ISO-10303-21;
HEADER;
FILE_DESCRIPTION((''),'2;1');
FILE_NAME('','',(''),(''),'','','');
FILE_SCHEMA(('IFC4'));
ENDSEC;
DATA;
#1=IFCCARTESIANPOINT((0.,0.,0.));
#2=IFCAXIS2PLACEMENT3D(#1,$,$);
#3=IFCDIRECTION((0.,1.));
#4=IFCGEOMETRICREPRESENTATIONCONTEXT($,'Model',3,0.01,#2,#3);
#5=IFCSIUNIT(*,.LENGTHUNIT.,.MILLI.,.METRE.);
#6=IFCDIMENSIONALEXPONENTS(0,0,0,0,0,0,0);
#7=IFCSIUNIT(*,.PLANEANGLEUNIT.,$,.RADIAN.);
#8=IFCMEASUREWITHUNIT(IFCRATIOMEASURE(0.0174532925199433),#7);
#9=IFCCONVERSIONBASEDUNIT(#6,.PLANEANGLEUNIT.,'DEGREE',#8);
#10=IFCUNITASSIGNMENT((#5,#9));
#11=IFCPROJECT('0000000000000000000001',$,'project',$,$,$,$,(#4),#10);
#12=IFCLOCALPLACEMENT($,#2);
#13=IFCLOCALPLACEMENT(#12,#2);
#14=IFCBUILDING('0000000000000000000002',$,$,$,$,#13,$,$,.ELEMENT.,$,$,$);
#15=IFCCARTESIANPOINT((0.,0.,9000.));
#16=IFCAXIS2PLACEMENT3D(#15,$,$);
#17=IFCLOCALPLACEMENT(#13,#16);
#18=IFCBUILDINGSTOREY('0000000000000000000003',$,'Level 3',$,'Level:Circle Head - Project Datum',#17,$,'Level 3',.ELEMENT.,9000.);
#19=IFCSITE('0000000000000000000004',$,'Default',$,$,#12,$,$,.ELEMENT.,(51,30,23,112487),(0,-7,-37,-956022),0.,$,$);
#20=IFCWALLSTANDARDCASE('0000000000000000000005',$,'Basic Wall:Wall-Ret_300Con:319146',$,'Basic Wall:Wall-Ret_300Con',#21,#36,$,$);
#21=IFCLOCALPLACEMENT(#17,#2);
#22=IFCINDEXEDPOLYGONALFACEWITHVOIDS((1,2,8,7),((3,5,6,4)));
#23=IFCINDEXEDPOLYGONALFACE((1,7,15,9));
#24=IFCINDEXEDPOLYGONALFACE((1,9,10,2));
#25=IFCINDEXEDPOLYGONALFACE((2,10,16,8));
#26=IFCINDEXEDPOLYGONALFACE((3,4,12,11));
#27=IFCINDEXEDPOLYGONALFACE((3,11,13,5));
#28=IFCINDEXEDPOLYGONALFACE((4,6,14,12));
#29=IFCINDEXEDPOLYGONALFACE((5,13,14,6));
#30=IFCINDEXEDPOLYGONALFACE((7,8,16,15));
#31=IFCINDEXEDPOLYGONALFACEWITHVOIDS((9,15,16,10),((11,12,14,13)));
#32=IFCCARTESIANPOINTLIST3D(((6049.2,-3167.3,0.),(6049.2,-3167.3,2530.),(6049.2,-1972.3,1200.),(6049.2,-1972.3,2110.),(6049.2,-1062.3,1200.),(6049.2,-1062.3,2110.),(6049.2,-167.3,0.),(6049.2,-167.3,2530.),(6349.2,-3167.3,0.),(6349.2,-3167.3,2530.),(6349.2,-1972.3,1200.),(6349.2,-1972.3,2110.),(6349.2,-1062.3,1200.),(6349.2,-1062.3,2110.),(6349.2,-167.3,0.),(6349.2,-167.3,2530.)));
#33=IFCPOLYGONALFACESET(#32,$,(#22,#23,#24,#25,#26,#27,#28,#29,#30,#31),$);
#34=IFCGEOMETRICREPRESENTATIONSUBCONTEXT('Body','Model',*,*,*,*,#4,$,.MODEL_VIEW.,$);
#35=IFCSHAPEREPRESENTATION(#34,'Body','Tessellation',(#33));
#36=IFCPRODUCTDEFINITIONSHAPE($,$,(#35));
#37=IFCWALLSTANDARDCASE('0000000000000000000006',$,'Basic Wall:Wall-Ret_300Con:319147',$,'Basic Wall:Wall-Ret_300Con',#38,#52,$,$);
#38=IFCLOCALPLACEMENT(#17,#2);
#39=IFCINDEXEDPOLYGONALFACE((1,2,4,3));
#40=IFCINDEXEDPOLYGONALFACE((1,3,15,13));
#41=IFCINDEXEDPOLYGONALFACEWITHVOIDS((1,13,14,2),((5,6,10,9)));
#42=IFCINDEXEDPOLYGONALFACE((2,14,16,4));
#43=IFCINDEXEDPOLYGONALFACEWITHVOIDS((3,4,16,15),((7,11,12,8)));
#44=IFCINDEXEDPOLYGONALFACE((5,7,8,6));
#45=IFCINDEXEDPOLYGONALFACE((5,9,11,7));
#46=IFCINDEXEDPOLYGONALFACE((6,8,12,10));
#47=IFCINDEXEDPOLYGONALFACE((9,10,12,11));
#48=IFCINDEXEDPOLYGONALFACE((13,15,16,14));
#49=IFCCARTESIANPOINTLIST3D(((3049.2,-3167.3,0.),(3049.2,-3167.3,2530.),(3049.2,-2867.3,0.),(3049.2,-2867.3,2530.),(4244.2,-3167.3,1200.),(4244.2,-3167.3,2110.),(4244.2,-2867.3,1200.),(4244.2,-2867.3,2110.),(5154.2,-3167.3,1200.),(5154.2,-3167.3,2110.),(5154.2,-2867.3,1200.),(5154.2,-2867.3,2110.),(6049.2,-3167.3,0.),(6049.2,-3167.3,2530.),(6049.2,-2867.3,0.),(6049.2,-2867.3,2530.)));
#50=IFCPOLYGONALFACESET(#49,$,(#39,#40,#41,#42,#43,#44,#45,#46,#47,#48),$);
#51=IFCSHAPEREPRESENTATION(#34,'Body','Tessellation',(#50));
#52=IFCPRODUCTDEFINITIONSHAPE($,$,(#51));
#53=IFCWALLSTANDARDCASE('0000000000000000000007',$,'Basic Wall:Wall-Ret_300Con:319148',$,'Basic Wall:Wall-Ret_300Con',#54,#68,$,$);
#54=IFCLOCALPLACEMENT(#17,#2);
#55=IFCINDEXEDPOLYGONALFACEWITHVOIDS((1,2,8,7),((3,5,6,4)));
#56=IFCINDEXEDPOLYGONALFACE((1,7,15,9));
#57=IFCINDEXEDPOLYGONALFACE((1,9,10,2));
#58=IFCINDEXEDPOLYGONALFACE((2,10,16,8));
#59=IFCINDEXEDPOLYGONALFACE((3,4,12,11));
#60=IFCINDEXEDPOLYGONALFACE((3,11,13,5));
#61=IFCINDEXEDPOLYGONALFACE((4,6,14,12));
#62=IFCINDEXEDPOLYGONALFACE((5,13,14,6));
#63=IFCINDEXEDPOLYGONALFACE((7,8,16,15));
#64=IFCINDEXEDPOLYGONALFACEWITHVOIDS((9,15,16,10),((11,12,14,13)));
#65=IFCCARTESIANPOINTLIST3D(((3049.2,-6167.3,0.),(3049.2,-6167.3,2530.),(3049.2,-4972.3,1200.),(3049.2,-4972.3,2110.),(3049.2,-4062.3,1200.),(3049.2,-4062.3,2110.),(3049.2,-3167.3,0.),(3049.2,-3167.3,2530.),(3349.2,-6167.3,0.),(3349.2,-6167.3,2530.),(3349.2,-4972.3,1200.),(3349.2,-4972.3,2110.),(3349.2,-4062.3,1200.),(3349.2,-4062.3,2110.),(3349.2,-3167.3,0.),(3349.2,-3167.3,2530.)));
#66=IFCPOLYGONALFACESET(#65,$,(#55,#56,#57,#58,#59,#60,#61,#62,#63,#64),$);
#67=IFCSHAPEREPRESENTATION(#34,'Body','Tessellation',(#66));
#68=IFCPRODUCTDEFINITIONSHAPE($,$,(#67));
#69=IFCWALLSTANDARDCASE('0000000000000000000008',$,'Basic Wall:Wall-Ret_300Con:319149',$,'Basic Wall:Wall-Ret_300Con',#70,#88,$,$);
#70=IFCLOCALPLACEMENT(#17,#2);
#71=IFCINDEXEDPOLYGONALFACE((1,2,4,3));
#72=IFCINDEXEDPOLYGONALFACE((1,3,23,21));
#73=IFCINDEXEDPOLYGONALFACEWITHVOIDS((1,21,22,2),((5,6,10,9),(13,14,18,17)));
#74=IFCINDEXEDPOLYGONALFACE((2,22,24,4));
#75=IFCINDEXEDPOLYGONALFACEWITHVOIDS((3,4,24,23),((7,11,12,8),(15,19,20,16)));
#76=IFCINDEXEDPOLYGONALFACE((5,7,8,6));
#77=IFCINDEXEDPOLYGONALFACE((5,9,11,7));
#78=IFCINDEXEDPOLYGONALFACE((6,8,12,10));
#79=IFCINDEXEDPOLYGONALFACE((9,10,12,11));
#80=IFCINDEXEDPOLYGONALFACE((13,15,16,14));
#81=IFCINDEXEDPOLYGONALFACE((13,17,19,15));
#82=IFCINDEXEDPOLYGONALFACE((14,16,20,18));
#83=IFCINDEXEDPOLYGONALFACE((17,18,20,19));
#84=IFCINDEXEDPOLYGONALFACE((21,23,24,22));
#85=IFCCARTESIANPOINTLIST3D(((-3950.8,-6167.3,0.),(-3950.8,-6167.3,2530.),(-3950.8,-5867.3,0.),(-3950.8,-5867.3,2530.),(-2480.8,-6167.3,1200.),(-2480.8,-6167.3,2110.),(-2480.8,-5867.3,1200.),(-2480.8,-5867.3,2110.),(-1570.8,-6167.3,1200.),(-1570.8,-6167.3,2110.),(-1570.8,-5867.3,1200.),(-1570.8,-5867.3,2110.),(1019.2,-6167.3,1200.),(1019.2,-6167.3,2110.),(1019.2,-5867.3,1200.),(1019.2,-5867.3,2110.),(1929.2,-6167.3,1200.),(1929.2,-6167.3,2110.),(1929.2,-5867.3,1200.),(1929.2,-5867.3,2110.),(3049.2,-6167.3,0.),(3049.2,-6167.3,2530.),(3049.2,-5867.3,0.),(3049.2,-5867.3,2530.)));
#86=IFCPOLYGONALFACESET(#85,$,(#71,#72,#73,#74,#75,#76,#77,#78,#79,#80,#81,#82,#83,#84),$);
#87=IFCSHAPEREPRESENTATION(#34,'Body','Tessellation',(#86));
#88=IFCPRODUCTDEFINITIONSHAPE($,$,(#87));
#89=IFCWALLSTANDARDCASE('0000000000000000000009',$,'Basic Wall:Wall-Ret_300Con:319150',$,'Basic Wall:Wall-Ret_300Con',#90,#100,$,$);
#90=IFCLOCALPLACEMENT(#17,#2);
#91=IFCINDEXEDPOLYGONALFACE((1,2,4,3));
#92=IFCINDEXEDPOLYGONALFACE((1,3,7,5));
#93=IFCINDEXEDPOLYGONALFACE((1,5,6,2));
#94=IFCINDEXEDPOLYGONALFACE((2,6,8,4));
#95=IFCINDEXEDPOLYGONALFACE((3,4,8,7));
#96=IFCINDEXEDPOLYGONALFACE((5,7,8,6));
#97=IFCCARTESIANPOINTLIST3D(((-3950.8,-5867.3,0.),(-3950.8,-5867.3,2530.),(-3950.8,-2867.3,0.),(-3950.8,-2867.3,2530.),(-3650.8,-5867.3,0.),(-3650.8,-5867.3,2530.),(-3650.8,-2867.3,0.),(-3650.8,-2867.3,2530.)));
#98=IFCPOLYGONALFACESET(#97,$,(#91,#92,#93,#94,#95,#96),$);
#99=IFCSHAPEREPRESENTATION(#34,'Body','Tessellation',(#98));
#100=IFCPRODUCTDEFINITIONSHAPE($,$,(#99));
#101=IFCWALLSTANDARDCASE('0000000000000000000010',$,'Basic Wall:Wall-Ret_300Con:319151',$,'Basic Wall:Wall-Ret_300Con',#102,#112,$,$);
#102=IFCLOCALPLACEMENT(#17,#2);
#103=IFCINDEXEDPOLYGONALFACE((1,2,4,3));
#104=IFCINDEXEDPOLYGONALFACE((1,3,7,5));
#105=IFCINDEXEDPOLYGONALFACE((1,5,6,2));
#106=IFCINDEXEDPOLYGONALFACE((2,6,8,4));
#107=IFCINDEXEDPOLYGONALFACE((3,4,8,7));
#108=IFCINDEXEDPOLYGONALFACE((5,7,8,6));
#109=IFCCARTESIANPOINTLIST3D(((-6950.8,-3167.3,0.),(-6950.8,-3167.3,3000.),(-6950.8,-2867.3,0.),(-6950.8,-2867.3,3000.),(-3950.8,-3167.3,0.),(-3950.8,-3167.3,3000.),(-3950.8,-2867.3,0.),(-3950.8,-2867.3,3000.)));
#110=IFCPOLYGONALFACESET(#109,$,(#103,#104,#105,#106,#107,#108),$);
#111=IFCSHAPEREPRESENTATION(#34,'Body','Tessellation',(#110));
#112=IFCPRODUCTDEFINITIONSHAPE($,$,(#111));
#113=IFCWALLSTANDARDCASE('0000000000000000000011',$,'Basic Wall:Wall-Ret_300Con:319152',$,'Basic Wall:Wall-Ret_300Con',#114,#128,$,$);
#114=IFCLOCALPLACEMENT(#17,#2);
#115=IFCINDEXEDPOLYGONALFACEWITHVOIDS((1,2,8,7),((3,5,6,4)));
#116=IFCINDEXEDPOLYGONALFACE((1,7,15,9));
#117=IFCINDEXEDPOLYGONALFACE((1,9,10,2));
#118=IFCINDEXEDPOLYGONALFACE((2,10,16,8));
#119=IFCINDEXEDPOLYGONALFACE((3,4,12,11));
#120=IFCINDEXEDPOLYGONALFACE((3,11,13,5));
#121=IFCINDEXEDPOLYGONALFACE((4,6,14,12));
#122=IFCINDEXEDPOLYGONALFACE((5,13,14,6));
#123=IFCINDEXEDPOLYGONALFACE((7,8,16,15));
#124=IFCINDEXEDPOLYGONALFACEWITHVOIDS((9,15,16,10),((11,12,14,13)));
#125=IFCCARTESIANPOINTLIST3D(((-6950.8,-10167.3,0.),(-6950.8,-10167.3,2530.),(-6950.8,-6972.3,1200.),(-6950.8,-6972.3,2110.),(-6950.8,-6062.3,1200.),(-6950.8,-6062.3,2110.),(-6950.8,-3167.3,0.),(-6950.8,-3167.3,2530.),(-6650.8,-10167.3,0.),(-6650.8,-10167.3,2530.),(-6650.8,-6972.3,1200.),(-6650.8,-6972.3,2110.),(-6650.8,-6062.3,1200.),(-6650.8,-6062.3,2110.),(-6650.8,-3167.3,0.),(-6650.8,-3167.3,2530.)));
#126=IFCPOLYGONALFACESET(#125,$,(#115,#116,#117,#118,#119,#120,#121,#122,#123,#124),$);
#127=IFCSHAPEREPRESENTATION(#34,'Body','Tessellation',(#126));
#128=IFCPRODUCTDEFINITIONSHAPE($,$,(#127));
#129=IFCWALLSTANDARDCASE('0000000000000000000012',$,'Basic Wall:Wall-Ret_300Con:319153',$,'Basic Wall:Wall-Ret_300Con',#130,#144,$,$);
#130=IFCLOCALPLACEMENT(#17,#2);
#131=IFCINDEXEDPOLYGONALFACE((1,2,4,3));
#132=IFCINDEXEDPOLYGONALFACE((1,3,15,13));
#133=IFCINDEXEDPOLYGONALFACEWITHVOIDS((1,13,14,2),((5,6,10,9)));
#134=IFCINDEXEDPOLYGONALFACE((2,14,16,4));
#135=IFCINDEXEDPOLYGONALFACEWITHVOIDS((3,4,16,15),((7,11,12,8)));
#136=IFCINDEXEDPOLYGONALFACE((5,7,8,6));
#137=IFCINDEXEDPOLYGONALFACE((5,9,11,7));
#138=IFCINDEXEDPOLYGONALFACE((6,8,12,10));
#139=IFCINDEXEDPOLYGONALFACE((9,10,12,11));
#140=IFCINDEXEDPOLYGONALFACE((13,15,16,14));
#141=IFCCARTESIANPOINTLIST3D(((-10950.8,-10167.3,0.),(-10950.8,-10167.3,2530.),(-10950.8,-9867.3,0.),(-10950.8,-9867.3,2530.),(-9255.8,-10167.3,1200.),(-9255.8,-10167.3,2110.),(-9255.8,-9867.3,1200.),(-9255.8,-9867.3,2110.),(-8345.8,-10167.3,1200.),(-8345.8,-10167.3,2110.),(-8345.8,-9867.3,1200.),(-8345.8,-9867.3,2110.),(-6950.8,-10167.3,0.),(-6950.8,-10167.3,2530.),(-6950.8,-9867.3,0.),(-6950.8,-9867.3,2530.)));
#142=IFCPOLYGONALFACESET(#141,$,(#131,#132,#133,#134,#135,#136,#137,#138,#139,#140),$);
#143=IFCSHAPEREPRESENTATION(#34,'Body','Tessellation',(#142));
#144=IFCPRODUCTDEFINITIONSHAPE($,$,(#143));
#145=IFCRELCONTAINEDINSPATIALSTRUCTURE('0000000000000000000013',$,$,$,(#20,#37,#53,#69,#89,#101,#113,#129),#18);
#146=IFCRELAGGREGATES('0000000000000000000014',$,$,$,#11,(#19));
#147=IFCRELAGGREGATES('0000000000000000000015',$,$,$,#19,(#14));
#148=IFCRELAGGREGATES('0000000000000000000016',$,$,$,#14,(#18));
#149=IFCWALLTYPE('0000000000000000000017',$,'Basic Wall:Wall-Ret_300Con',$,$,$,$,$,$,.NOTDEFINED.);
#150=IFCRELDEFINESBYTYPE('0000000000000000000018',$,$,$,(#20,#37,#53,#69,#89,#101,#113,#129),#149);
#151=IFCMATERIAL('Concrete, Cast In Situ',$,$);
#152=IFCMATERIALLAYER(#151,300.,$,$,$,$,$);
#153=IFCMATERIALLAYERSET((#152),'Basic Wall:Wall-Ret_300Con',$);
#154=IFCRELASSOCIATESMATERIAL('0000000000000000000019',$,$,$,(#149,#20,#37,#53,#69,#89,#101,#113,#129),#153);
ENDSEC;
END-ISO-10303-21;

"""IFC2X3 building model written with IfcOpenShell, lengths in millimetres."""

from ifc_helpers import new_model, entity, si_unit, converted_unit, direction, frame, frame_2d, origin, place, context, subcontext, project, spatial, polyline, rectangle, extrude, clip, bounded_halfspace, material, layer, layer_set, layer_usage, type_object, element, save


model = new_model("IFC2X3")

# Units and contexts
model_context = context("Model", 3, precision=0.01, world=origin(), true_north=direction((0.0, 1.0)))
body_context = subcontext(model_context, "Body", "Model", "MODEL_VIEW")
ifc_project = project(units=[si_unit("LENGTHUNIT", "METRE", prefix="MILLI"), converted_unit("PLANEANGLEUNIT", "DEGREE", entity("IfcRatioMeasure", 0.0174532925199433), si_unit("PLANEANGLEUNIT", "RADIAN"), dimensions=[0, 0, 0, 0, 0, 0, 0])], contexts=[model_context])

# Site, building, storey
site_placement = place(None, origin())
site = spatial("IfcSite", under=ifc_project, at=site_placement, Name="Default", CompositionType="ELEMENT", RefLatitude=(51, 30, 23, 112487), RefLongitude=(0, -7, -37, -956022), RefElevation=0.0)
building_placement = place(site_placement, origin())
building = spatial("IfcBuilding", under=site, at=building_placement, CompositionType="ELEMENT")
storey_placement = place(building_placement, frame((0.0, 0.0, 9000.0)))
storey = spatial("IfcBuildingStorey", under=building, at=storey_placement, Name="Level 3", ObjectType="Level:Circle Head - Project Datum", LongName="Level 3", CompositionType="ELEMENT", Elevation=9000.0)

# Walls, openings
ifc_material_1 = material(Name="Concrete, Cast In Situ")
ifc_layer_1 = layer(ifc_material_1, 300.0)
ifc_layer_set_1 = layer_set([ifc_layer_1], Name="Basic Wall:Wall-Ret_300Con")
wall_type = type_object("IfcWallType", Name="Basic Wall:Wall-Ret_300Con", PredefinedType="NOTDEFINED", material=ifc_layer_set_1)
ifc_layer_usage_1 = layer_usage(ifc_layer_set_1, "AXIS2", "NEGATIVE", 150.0)
wall_1_placement = place(storey_placement, frame((6199.2, -167.3, 0.0), z_axis=(0.0, 0.0, 1.0), x_axis=(0.0, -1.0, 0.0)))
wall_1 = element("IfcWallStandardCase", 1, at=wall_1_placement, inside=storey, type_object=wall_type, material=ifc_layer_usage_1, Name="Basic Wall:Wall-Ret_300Con:319146", ObjectType="Basic Wall:Wall-Ret_300Con", context=body_context, shape_type="Clipping", body=[
    clip(extrude(rectangle(XDim=3000.0, YDim=300.0, at=frame_2d((1500.0, 0.0), x_axis=(-1.0, 0.0))), origin(), (0.0, 0.0, 1.0), 2530.0), bounded_halfspace(frame((0.0, -150.0, 2530.0), z_axis=(0.0, 0.0, -1.0), x_axis=(0.0, 1.0, 0.0)), True, frame((0.0, -150.0, 2530.0)), polyline([(0.0, 0.0), (2700.0, 0.0), (2998.0, 0.0), (2998.0, 298.7), (0.0, 298.7), (0.0, 0.0)]))),
])
opening_1_placement = place(wall_1_placement, frame((1805.0, 150.0, 1200.0)))
element("IfcOpeningElement", 2, at=opening_1_placement, cuts=wall_1, ObjectType="Opening", context=body_context, shape_type="SweptSolid", body=[
    extrude(rectangle(XDim=910.0, YDim=910.0, at=frame_2d((455.0, 455.0), x_axis=(-1.0, 0.0))), frame((0.0, 0.0, 0.0), z_axis=(0.0, -1.0, 0.0), x_axis=(0.0, 0.0, 1.0)), (0.0, 0.0, 1.0), 300.0),
])
ifc_layer_usage_2 = layer_usage(ifc_layer_set_1, "AXIS2", "NEGATIVE", 150.0)
wall_2_placement = place(storey_placement, frame((6049.2, -3017.3, 0.0), z_axis=(0.0, 0.0, 1.0), x_axis=(-1.0, 0.0, 0.0)))
wall_2 = element("IfcWallStandardCase", 3, at=wall_2_placement, inside=storey, type_object=wall_type, material=ifc_layer_usage_2, Name="Basic Wall:Wall-Ret_300Con:319147", ObjectType="Basic Wall:Wall-Ret_300Con", context=body_context, shape_type="Clipping", body=[
    clip(extrude(rectangle(XDim=3000.0, YDim=300.0, at=frame_2d((1500.0, 0.0), x_axis=(-1.0, 0.0))), origin(), (0.0, 0.0, 1.0), 2530.0), bounded_halfspace(frame((0.0, -150.0, 2530.0), z_axis=(0.0, 0.0, -1.0), x_axis=(-1.0, 0.0, 0.0)), True, frame((0.0, -150.0, 2530.0)), polyline([(0.0, 0.0), (3000.0, 0.0), (3000.0, 298.0), (2701.3, 298.0), (0.0, 298.0), (0.0, 0.0)]))),
])
opening_2_placement = place(wall_2_placement, frame((1805.0, 150.0, 1200.0)))
element("IfcOpeningElement", 4, at=opening_2_placement, cuts=wall_2, ObjectType="Opening", context=body_context, shape_type="SweptSolid", body=[
    extrude(rectangle(XDim=910.0, YDim=910.0, at=frame_2d((455.0, 455.0), x_axis=(-1.0, 0.0))), frame((0.0, 0.0, 0.0), z_axis=(0.0, -1.0, 0.0), x_axis=(0.0, 0.0, 1.0)), (0.0, 0.0, 1.0), 300.0),
])
ifc_layer_usage_3 = layer_usage(ifc_layer_set_1, "AXIS2", "NEGATIVE", 150.0)
wall_3_placement = place(storey_placement, frame((3199.2, -3167.3, 0.0), z_axis=(0.0, 0.0, 1.0), x_axis=(0.0, -1.0, 0.0)))
wall_3 = element("IfcWallStandardCase", 5, at=wall_3_placement, inside=storey, type_object=wall_type, material=ifc_layer_usage_3, Name="Basic Wall:Wall-Ret_300Con:319148", ObjectType="Basic Wall:Wall-Ret_300Con", context=body_context, shape_type="Clipping", body=[
    clip(extrude(rectangle(XDim=3000.0, YDim=300.0, at=frame_2d((1500.0, 0.0), x_axis=(-1.0, 0.0))), origin(), (0.0, 0.0, 1.0), 2530.0), bounded_halfspace(frame((0.0, -150.0, 2530.0), z_axis=(0.0, 0.0, -1.0), x_axis=(0.0, 1.0, 0.0)), True, frame((0.0, -150.0, 2530.0)), polyline([(0.0, 0.0), (2700.0, 0.0), (2998.0, 0.0), (2998.0, 298.7), (0.0, 298.7), (0.0, 0.0)]))),
])
opening_3_placement = place(wall_3_placement, frame((895.0, -150.0, 1200.0)))
element("IfcOpeningElement", 6, at=opening_3_placement, cuts=wall_3, ObjectType="Opening", context=body_context, shape_type="SweptSolid", body=[
    extrude(rectangle(XDim=910.0, YDim=910.0, at=frame_2d((455.0, 455.0), x_axis=(-1.0, 0.0))), frame((0.0, 0.0, 0.0), z_axis=(0.0, 1.0, 0.0), x_axis=(0.0, 0.0, 1.0)), (0.0, 0.0, 1.0), 300.0),
])

# Wall, openings
ifc_layer_usage_4 = layer_usage(ifc_layer_set_1, "AXIS2", "NEGATIVE", 150.0)
wall_4_placement = place(storey_placement, frame((3049.2, -6017.3, 0.0), z_axis=(0.0, 0.0, 1.0), x_axis=(-1.0, 0.0, 0.0)))
wall_4 = element("IfcWallStandardCase", 7, at=wall_4_placement, inside=storey, type_object=wall_type, material=ifc_layer_usage_4, Name="Basic Wall:Wall-Ret_300Con:319149", ObjectType="Basic Wall:Wall-Ret_300Con", context=body_context, shape_type="Clipping", body=[
    clip(extrude(rectangle(XDim=7000.0, YDim=300.0, at=frame_2d((3500.0, 0.0), x_axis=(-1.0, 0.0))), origin(), (0.0, 0.0, 1.0), 2530.0), bounded_halfspace(frame((0.0, -150.0, 2530.0), z_axis=(0.0, 0.0, -1.0), x_axis=(-1.0, 0.0, 0.0)), True, frame((0.0, -150.0, 2530.0)), polyline([(0.0, 0.0), (6700.0, 0.0), (7000.0, 0.0), (7000.0, 298.0), (0.0, 298.0), (0.0, 0.0)]))),
])
opening_4_placement = place(wall_4_placement, frame((2030.0, 150.0, 1200.0)))
element("IfcOpeningElement", 8, at=opening_4_placement, cuts=wall_4, ObjectType="Opening", context=body_context, shape_type="SweptSolid", body=[
    extrude(rectangle(XDim=910.0, YDim=910.0, at=frame_2d((455.0, 455.0), x_axis=(-1.0, 0.0))), frame((0.0, 0.0, 0.0), z_axis=(0.0, -1.0, 0.0), x_axis=(0.0, 0.0, 1.0)), (0.0, 0.0, 1.0), 300.0),
])
opening_5_placement = place(wall_4_placement, frame((4620.0, -150.0, 1200.0)))
element("IfcOpeningElement", 9, at=opening_5_placement, cuts=wall_4, ObjectType="Opening", context=body_context, shape_type="SweptSolid", body=[
    extrude(rectangle(XDim=910.0, YDim=910.0, at=frame_2d((455.0, 455.0), x_axis=(-1.0, 0.0))), frame((0.0, 0.0, 0.0), z_axis=(0.0, 1.0, 0.0), x_axis=(0.0, 0.0, 1.0)), (0.0, 0.0, 1.0), 300.0),
])

# Walls
ifc_layer_usage_5 = layer_usage(ifc_layer_set_1, "AXIS2", "NEGATIVE", 150.0)
wall_5_placement = place(storey_placement, frame((-3800.8, -5867.3, 0.0), z_axis=(0.0, 0.0, 1.0), x_axis=(0.0, 1.0, 0.0)))
element("IfcWallStandardCase", 10, at=wall_5_placement, inside=storey, type_object=wall_type, material=ifc_layer_usage_5, Name="Basic Wall:Wall-Ret_300Con:319150", ObjectType="Basic Wall:Wall-Ret_300Con", context=body_context, shape_type="Clipping", body=[
    clip(extrude(rectangle(XDim=3000.0, YDim=300.0, at=frame_2d((1500.0, 0.0), x_axis=(-1.0, 0.0))), origin(), (0.0, 0.0, 1.0), 2530.0), bounded_halfspace(frame((0.0, -150.0, 2530.0), z_axis=(0.0, 0.0, -1.0), x_axis=(0.0, -1.0, 0.0)), True, frame((0.0, -150.0, 2530.0)), polyline([(0.0, 0.0), (3000.0, 0.0), (3000.0, 300.0), (0.0, 300.0), (0.0, 0.0)]))),
])
ifc_layer_usage_6 = layer_usage(ifc_layer_set_1, "AXIS2", "NEGATIVE", 150.0)
wall_6_placement = place(storey_placement, frame((-3950.8, -3017.3, 0.0), z_axis=(0.0, 0.0, 1.0), x_axis=(-1.0, 0.0, 0.0)))
element("IfcWallStandardCase", 11, at=wall_6_placement, inside=storey, type_object=wall_type, material=ifc_layer_usage_6, Name="Basic Wall:Wall-Ret_300Con:319151", ObjectType="Basic Wall:Wall-Ret_300Con", context=body_context, shape_type="SweptSolid", body=[
    extrude(rectangle(XDim=3000.0, YDim=300.0, at=frame_2d((1500.0, 0.0), x_axis=(-1.0, 0.0))), origin(), (0.0, 0.0, 1.0), 3000.0),
])

# Walls, openings
ifc_layer_usage_7 = layer_usage(ifc_layer_set_1, "AXIS2", "NEGATIVE", 150.0)
wall_7_placement = place(storey_placement, frame((-6800.8, -3167.3, 0.0), z_axis=(0.0, 0.0, 1.0), x_axis=(0.0, -1.0, 0.0)))
wall_7 = element("IfcWallStandardCase", 12, at=wall_7_placement, inside=storey, type_object=wall_type, material=ifc_layer_usage_7, Name="Basic Wall:Wall-Ret_300Con:319152", ObjectType="Basic Wall:Wall-Ret_300Con", context=body_context, shape_type="Clipping", body=[
    clip(extrude(rectangle(XDim=7000.0, YDim=300.0, at=frame_2d((3500.0, 0.0), x_axis=(-1.0, 0.0))), origin(), (0.0, 0.0, 1.0), 2530.0), bounded_halfspace(frame((0.0, -150.0, 2530.0), z_axis=(0.0, 0.0, -1.0), x_axis=(0.0, 1.0, 0.0)), True, frame((0.0, -150.0, 2530.0)), polyline([(0.0, 0.0), (6700.0, 0.0), (6998.0, 0.0), (6998.0, 298.7), (0.0, 298.7), (0.0, 0.0)]))),
])
opening_6_placement = place(wall_7_placement, frame((3805.0, 150.0, 1200.0)))
element("IfcOpeningElement", 13, at=opening_6_placement, cuts=wall_7, ObjectType="Opening", context=body_context, shape_type="SweptSolid", body=[
    extrude(rectangle(XDim=910.0, YDim=910.0, at=frame_2d((455.0, 455.0), x_axis=(-1.0, 0.0))), frame((0.0, 0.0, 0.0), z_axis=(0.0, -1.0, 0.0), x_axis=(0.0, 0.0, 1.0)), (0.0, 0.0, 1.0), 300.0),
])
ifc_layer_usage_8 = layer_usage(ifc_layer_set_1, "AXIS2", "NEGATIVE", 150.0)
wall_8_placement = place(storey_placement, frame((-6950.8, -10017.3, 0.0), z_axis=(0.0, 0.0, 1.0), x_axis=(-1.0, 0.0, 0.0)))
wall_8 = element("IfcWallStandardCase", 14, at=wall_8_placement, inside=storey, type_object=wall_type, material=ifc_layer_usage_8, Name="Basic Wall:Wall-Ret_300Con:319153", ObjectType="Basic Wall:Wall-Ret_300Con", context=body_context, shape_type="Clipping", body=[
    clip(extrude(rectangle(XDim=4000.0, YDim=300.0, at=frame_2d((2000.0, 0.0), x_axis=(-1.0, 0.0))), origin(), (0.0, 0.0, 1.0), 2530.0), bounded_halfspace(frame((0.0, -150.0, 2530.0), z_axis=(0.0, 0.0, -1.0), x_axis=(-1.0, 0.0, 0.0)), True, frame((0.0, -150.0, 2530.0)), polyline([(0.0, 0.0), (3700.0, 0.0), (4000.0, 0.0), (4000.0, 298.0), (0.0, 298.0), (0.0, 0.0)]))),
])
opening_7_placement = place(wall_8_placement, frame((2305.0, 150.0, 1200.0)))
element("IfcOpeningElement", 15, at=opening_7_placement, cuts=wall_8, ObjectType="Opening", context=body_context, shape_type="SweptSolid", body=[
    extrude(rectangle(XDim=910.0, YDim=910.0, at=frame_2d((455.0, 455.0), x_axis=(-1.0, 0.0))), frame((0.0, 0.0, 0.0), z_axis=(0.0, -1.0, 0.0), x_axis=(0.0, 0.0, 1.0)), (0.0, 0.0, 1.0), 300.0),
])

save(model, "model.ifc")
